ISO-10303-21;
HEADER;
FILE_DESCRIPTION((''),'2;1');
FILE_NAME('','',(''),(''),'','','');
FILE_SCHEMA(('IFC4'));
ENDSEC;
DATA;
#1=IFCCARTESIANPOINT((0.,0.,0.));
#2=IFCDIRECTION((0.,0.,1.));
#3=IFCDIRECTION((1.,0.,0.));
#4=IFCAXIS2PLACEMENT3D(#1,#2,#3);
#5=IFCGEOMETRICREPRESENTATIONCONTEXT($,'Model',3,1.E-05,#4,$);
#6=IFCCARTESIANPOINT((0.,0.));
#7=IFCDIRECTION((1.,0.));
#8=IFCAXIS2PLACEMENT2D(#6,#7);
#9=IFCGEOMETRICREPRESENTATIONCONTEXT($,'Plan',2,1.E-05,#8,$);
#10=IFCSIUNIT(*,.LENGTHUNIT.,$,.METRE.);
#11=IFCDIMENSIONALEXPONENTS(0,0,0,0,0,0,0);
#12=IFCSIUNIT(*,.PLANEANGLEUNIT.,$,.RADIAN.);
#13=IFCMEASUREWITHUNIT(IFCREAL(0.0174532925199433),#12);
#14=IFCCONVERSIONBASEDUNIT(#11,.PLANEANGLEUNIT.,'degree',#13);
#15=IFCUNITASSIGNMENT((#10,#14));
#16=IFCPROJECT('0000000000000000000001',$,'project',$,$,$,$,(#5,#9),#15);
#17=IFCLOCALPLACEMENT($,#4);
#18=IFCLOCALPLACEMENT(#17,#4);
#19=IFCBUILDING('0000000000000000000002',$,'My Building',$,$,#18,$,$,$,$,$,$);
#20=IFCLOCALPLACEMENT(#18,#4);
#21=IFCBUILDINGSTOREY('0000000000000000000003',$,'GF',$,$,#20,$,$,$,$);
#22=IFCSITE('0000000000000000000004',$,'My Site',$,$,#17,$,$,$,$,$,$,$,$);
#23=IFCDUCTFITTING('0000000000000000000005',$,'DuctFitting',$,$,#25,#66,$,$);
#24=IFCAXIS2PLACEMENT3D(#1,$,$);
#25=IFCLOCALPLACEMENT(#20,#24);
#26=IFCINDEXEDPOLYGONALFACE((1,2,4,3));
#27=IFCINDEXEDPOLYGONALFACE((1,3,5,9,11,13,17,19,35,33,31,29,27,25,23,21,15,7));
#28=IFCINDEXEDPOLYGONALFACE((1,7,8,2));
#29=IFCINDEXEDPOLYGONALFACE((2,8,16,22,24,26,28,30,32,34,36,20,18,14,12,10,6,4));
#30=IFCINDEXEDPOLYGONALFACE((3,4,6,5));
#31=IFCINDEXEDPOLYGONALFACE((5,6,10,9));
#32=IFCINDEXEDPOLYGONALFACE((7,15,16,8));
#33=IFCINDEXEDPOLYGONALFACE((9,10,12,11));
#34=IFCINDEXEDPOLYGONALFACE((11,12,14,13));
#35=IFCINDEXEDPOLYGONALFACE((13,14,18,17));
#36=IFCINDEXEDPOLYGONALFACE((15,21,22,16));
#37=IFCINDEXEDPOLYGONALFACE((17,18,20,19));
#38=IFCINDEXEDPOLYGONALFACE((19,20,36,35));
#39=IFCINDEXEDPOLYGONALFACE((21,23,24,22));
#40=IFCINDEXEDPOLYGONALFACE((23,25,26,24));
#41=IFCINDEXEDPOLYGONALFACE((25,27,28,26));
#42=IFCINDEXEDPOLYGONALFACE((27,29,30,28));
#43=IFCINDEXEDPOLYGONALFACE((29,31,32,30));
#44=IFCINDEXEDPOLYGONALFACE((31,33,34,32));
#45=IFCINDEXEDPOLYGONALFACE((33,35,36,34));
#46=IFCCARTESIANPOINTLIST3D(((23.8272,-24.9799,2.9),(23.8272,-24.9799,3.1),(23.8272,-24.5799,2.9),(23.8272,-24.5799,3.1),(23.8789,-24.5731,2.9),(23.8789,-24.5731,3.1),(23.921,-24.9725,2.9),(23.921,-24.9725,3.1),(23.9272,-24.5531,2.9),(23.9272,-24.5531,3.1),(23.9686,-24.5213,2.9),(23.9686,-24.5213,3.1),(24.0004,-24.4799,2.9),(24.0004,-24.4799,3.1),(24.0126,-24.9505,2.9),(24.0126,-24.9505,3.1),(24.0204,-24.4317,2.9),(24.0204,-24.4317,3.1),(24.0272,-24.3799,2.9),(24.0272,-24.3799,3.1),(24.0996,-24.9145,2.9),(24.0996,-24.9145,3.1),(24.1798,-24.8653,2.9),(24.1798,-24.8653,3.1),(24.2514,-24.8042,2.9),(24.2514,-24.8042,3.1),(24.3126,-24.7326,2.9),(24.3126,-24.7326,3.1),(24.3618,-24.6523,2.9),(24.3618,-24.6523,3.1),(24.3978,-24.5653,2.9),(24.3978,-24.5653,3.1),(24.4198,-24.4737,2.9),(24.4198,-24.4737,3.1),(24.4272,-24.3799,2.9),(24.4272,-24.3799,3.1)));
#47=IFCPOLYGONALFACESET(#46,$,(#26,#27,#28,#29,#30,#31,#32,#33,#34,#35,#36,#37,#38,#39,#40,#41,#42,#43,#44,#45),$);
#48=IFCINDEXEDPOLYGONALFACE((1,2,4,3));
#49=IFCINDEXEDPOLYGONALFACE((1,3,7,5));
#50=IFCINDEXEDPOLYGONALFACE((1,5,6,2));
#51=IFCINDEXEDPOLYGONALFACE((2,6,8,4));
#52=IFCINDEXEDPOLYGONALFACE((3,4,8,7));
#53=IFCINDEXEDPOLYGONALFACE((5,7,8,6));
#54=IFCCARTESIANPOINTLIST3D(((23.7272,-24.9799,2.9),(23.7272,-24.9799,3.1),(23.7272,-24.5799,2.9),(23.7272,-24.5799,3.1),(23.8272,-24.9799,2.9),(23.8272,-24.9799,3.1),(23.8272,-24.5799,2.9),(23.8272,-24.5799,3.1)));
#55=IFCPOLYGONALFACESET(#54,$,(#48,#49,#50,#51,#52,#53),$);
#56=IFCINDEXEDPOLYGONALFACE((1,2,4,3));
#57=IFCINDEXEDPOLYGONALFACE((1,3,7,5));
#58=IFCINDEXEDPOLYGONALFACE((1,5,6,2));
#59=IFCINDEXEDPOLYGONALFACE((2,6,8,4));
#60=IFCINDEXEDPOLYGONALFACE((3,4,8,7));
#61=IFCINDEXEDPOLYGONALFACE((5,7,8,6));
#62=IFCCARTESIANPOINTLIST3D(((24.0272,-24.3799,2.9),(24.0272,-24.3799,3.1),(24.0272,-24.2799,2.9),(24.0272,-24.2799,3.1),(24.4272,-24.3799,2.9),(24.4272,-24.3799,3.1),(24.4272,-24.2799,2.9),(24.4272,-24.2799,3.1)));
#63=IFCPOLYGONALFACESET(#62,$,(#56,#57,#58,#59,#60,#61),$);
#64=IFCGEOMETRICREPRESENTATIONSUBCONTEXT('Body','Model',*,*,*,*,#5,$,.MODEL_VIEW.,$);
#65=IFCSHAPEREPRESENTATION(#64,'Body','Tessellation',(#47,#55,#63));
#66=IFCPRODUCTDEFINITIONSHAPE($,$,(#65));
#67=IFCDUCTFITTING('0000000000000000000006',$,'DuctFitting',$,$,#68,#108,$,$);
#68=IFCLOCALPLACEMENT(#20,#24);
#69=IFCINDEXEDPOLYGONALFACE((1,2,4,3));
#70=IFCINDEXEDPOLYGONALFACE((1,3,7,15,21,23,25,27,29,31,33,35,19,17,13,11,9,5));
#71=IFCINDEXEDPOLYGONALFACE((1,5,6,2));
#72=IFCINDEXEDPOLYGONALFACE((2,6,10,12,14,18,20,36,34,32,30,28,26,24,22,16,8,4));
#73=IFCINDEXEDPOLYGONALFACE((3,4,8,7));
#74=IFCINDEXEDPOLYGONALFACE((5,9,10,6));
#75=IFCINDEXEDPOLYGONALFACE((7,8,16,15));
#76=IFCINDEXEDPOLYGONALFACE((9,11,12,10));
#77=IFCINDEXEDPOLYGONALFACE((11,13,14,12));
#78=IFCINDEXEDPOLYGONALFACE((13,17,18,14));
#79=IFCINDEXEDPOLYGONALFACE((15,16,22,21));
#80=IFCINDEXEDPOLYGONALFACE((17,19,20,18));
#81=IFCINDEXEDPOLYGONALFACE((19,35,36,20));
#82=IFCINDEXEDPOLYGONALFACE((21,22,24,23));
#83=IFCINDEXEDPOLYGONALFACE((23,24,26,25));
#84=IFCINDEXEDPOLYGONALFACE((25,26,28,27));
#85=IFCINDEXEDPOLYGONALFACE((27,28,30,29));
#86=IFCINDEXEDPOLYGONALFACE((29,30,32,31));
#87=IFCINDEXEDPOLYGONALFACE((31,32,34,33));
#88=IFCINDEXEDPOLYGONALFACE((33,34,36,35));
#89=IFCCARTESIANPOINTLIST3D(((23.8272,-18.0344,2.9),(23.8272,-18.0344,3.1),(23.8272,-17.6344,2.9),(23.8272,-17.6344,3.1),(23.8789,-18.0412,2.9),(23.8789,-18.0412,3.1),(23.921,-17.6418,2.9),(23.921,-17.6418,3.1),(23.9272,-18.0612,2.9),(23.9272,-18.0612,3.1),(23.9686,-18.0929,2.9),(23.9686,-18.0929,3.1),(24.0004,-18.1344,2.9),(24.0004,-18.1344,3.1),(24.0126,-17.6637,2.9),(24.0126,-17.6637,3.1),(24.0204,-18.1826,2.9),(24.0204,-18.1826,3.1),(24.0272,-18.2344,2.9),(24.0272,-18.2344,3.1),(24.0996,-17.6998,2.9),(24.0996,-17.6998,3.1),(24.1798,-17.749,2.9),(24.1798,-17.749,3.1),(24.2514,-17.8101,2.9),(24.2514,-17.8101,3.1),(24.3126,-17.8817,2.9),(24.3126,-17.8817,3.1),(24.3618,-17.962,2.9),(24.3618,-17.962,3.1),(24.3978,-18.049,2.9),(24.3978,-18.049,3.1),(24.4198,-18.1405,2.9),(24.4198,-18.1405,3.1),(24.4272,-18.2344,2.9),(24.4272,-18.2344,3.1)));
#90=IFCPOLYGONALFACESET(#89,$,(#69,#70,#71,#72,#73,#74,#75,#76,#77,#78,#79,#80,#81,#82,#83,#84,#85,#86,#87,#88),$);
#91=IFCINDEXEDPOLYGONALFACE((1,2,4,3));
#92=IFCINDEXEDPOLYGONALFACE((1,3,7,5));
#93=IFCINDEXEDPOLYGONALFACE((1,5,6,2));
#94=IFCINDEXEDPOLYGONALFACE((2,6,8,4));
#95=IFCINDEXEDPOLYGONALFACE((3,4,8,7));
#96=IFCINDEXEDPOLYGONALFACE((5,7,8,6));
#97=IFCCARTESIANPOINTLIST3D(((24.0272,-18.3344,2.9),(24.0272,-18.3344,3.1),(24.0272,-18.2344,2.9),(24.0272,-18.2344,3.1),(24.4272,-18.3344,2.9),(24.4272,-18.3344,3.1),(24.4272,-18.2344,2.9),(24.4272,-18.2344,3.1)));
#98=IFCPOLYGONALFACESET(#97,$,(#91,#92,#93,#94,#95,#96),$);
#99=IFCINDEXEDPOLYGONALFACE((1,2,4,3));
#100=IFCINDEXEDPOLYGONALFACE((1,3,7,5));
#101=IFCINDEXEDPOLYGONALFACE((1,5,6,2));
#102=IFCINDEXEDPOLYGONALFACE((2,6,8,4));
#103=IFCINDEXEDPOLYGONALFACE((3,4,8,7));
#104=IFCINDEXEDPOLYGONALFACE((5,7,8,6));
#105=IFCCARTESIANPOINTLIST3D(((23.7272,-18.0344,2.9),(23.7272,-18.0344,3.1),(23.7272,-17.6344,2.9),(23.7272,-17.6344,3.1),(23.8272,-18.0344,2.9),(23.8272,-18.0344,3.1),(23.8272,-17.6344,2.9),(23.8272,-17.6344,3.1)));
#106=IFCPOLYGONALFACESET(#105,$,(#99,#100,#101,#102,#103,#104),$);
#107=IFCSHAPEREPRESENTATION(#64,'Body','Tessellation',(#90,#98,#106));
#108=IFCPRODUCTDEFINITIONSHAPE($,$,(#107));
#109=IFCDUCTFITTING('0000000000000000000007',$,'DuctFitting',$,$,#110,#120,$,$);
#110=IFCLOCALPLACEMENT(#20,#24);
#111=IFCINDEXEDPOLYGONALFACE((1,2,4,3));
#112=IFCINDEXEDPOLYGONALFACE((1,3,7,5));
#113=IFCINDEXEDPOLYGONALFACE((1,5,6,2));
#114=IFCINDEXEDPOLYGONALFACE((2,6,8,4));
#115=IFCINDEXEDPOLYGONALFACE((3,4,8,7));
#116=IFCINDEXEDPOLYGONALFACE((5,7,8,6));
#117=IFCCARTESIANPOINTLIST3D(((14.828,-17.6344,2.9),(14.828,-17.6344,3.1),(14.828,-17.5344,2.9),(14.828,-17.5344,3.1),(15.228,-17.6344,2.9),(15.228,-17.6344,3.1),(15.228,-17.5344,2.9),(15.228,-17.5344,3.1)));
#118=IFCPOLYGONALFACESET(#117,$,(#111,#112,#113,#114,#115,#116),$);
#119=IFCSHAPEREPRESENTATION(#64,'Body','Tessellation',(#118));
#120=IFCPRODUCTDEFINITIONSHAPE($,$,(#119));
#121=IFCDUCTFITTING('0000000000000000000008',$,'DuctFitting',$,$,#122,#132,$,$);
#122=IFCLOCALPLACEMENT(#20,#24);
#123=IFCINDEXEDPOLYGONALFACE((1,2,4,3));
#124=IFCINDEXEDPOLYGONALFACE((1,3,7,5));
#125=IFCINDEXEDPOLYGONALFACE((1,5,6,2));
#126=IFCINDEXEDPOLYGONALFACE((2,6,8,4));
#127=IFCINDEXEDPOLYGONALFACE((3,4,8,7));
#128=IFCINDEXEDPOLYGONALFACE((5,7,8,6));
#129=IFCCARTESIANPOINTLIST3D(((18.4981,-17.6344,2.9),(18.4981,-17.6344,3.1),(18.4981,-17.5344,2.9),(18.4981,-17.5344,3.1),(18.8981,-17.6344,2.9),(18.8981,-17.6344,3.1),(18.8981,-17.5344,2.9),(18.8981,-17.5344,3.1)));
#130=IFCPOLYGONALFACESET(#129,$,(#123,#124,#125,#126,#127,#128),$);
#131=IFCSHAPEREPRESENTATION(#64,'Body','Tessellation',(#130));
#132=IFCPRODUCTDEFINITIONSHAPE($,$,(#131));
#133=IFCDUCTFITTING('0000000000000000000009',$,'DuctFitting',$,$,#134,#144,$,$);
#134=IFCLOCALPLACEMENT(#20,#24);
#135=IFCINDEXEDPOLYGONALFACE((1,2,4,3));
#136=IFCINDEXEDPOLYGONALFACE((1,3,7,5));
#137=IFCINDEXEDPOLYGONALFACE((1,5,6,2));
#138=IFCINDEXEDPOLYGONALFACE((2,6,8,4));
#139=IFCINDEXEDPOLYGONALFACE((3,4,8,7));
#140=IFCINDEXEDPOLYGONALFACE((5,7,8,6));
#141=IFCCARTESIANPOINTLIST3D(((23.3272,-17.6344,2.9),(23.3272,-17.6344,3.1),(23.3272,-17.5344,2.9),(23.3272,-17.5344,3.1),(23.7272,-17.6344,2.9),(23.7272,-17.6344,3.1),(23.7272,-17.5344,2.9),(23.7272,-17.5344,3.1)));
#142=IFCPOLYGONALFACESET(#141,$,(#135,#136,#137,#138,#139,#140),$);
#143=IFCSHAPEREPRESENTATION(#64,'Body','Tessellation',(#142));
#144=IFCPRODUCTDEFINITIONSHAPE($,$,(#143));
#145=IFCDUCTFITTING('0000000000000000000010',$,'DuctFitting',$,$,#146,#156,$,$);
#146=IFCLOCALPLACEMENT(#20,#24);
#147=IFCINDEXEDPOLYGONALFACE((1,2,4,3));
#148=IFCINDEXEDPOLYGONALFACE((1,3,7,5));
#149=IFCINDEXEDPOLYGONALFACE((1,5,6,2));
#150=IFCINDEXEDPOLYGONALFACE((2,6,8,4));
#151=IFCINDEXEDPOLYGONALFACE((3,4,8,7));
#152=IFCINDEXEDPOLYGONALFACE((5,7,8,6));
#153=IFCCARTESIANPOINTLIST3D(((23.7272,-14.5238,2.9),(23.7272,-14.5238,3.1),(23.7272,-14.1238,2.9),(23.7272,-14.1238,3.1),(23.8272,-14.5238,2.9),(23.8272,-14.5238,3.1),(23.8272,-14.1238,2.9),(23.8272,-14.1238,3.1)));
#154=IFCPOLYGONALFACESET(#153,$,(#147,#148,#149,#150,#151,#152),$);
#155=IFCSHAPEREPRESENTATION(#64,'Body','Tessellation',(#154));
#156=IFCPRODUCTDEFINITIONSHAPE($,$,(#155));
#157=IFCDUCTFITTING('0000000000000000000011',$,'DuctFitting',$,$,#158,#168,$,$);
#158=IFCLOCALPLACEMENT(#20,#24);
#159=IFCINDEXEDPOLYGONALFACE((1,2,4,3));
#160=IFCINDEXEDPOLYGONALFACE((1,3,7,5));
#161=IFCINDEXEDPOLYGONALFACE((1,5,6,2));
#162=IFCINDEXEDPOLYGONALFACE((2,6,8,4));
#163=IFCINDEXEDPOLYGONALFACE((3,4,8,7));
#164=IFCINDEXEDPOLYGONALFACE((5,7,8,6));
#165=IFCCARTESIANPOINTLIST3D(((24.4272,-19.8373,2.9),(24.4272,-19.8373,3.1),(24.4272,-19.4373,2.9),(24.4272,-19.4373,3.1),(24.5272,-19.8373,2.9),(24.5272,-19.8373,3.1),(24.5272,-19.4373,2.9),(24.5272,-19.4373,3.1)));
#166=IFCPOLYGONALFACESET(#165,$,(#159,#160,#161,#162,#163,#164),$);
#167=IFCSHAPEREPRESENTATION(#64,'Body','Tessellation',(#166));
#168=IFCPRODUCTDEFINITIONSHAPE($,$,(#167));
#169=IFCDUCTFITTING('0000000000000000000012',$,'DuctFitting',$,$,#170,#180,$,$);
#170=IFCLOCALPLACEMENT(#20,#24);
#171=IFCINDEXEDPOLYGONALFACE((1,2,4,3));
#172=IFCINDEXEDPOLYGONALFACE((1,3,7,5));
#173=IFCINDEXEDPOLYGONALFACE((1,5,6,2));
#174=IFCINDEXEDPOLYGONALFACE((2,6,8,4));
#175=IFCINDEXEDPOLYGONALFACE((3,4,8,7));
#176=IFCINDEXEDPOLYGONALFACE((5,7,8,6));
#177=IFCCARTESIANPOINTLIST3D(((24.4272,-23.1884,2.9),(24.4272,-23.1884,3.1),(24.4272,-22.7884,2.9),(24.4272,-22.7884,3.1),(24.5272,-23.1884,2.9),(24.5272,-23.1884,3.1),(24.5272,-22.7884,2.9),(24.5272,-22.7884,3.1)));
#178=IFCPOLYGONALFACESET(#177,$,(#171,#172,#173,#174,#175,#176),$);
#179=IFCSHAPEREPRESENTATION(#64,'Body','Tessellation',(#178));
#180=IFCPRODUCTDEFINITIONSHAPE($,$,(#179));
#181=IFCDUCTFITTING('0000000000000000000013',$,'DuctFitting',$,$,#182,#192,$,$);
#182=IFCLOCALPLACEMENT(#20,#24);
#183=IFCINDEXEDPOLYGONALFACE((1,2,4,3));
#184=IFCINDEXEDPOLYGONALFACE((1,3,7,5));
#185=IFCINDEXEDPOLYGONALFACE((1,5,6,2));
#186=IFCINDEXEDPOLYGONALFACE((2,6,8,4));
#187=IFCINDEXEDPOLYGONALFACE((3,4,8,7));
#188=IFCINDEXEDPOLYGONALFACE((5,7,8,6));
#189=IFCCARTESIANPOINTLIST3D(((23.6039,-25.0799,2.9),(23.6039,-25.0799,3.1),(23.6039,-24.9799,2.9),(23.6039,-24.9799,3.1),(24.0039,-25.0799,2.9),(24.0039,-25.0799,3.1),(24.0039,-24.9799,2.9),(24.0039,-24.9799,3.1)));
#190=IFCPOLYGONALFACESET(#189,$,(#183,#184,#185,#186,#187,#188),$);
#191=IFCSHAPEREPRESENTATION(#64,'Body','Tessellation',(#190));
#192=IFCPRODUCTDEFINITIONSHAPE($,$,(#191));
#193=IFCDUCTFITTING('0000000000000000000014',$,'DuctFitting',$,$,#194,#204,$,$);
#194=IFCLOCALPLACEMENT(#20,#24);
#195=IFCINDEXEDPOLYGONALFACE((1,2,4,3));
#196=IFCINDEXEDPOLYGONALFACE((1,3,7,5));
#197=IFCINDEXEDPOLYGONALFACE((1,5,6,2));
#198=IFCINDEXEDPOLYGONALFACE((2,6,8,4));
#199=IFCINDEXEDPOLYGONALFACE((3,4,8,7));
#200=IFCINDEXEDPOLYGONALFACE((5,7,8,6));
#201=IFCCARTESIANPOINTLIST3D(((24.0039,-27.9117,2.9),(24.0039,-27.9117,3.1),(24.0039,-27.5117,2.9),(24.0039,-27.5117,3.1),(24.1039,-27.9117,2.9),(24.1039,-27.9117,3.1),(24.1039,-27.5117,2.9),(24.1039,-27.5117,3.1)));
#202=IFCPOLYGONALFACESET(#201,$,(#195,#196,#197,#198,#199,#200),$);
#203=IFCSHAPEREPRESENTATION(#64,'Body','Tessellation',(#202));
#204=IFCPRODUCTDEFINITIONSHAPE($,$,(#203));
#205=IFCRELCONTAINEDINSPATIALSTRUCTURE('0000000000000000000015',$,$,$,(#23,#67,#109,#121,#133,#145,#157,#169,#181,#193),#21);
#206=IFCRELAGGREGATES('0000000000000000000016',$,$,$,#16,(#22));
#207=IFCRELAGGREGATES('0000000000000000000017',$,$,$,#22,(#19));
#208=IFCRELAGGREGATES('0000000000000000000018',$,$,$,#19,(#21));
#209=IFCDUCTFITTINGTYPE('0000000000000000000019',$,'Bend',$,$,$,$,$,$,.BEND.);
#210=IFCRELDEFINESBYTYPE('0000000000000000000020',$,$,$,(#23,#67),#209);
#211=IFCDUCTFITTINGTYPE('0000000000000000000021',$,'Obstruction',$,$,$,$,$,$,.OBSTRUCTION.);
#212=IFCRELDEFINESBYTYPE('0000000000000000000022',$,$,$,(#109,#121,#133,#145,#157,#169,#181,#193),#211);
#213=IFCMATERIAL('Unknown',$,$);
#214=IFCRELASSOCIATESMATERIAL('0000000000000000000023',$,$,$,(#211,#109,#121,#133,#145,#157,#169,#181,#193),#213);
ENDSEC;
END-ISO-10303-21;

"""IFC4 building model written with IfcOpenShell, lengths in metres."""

from ifc_helpers import new_model, entity, si_unit, converted_unit, frame, origin_with_axes, origin_2d_with_axis, place, context, subcontext, project, spatial, line, arc, indexed_curve, rectangle, outline, extrude, source, transform, mapped, material, material_profile, profile_set, profile_usage, type_object, type_shapes, element, save


model = new_model("IFC4")

# Units and contexts
model_context = context("Model", 3, precision=1e-05, world=origin_with_axes())
plan_context = context("Plan", 2, precision=1e-05, world=origin_2d_with_axis())
body_context_1 = subcontext(model_context, "Body", "Model", "MODEL_VIEW")
ifc_project = project(units=[si_unit("LENGTHUNIT", "METRE"), converted_unit("PLANEANGLEUNIT", "degree", entity("IfcReal", 0.0174532925199433), si_unit("PLANEANGLEUNIT", "RADIAN"), dimensions=[0, 0, 0, 0, 0, 0, 0])], contexts=[model_context, plan_context])

# Site, building, storey
site_placement = place(None, origin_with_axes())
site = spatial("IfcSite", under=ifc_project, at=site_placement, Name="My Site")
building_placement = place(site_placement, origin_with_axes())
building = spatial("IfcBuilding", under=site, at=building_placement, Name="My Building")
storey_placement = place(building_placement, origin_with_axes())
storey = spatial("IfcBuildingStorey", under=building, at=storey_placement, Name="GF")

# Shared definitions
ifc_material = material(Name="Unknown")

# Duct fittings
duct_fitting_type_1 = type_object("IfcDuctFittingType", Name="Bend", PredefinedType="BEND")
shared_shape_1 = source(origin_with_axes(), body_context_1, "Body", "SweptSolid", [
    extrude(outline(indexed_curve([(-0.2, 0.0), (-0.2586, -0.1414), (-0.4, -0.2), (-0.4, -0.6), (0.0243, -0.4243), (0.2, 0.0)], segments=[arc(1, 2, 3), line(3, 4), arc(4, 5, 6), line(6, 1)])), frame((0.0, -0.1, -0.1), z_axis=(0.0, -1.0, 0.0), x_axis=(1.0, 0.0, 0.0)), (0.0, 0.0, -1.0), 0.2),
    extrude(rectangle(XDim=0.4, YDim=0.2), origin_with_axes(), (0.0, 0.0, -1.0), 0.1),
    extrude(rectangle(XDim=0.4, YDim=0.2), frame((-0.4, 0.0, -0.5), z_axis=(-1.0, 0.0, 0.0), x_axis=(0.0, 0.0, -1.0)), (0.0, 0.0, 1.0), 0.1),
])
type_shapes(duct_fitting_type_1, [shared_shape_1])
for number, where, z_axis, x_axis, name in (
    (1, (23.7272, -24.7799, 3.0), (-1.0, 0.000001, -0.000001), (-0.000001, -1.0, 0.0), "DuctFitting"),
    (2, (24.2272, -18.3344, 3.0), (0.0, -1.0, 0.0), (1.0, 0.0, 0.0), "DuctFitting"),
):
    element("IfcDuctFitting", number, at=place(storey_placement, frame(where, z_axis=z_axis, x_axis=x_axis)), inside=storey, type_object=duct_fitting_type_1, Name=name, context=body_context_1, shape_type="MappedRepresentation", body=[
        mapped(shared_shape_1, transform((0.0, 0.0, 0.0), x_axis=(1.0, 0.0, 0.0), y_axis=(0.0, 1.0, 0.0), z_axis=(0.0, 0.0, 1.0), scale=1.0)),
    ])
ifc_material_profile_1 = material_profile(ifc_material, rectangle(XDim=0.4, YDim=0.2))
ifc_profile_set_1 = profile_set([ifc_material_profile_1])
ifc_profile_usage_1 = profile_usage(ifc_profile_set_1, cardinal=5)
duct_fitting_type_2 = type_object("IfcDuctFittingType", Name="Obstruction", PredefinedType="OBSTRUCTION", material=ifc_profile_set_1)
duct_fitting_1_placement = place(storey_placement, frame((15.028, -17.6344, 3.0), z_axis=(0.0, 1.0, 0.0), x_axis=(-1.0, 0.0, 0.0)))
element("IfcDuctFitting", 3, at=duct_fitting_1_placement, inside=storey, type_object=duct_fitting_type_2, material=ifc_profile_usage_1, Name="DuctFitting", context=body_context_1, shape_type="SweptSolid", body=[
    extrude(rectangle(XDim=0.4, YDim=0.2), origin_with_axes(), (0.0, 0.0, 1.0), 0.1),
])
ifc_profile_usage_2 = profile_usage(ifc_profile_set_1, cardinal=5)
duct_fitting_2_placement = place(storey_placement, frame((18.6981, -17.6344, 3.0), z_axis=(0.0, 1.0, 0.0), x_axis=(-1.0, 0.0, 0.0)))
element("IfcDuctFitting", 4, at=duct_fitting_2_placement, inside=storey, type_object=duct_fitting_type_2, material=ifc_profile_usage_2, Name="DuctFitting", context=body_context_1, shape_type="SweptSolid", body=[
    extrude(rectangle(XDim=0.4, YDim=0.2), origin_with_axes(), (0.0, 0.0, 1.0), 0.1),
])
ifc_profile_usage_3 = profile_usage(ifc_profile_set_1, cardinal=5)
duct_fitting_3_placement = place(storey_placement, frame((23.5272, -17.6344, 3.0), z_axis=(0.0, 1.0, 0.0), x_axis=(-1.0, 0.0, 0.0)))
element("IfcDuctFitting", 5, at=duct_fitting_3_placement, inside=storey, type_object=duct_fitting_type_2, material=ifc_profile_usage_3, Name="DuctFitting", context=body_context_1, shape_type="SweptSolid", body=[
    extrude(rectangle(XDim=0.4, YDim=0.2), origin_with_axes(), (0.0, 0.0, 1.0), 0.1),
])
ifc_profile_usage_4 = profile_usage(ifc_profile_set_1, cardinal=5)
duct_fitting_4_placement = place(storey_placement, frame((23.7272, -14.3238, 3.0), z_axis=(1.0, 0.0, 0.0), x_axis=(0.0, 1.0, 0.0)))
element("IfcDuctFitting", 6, at=duct_fitting_4_placement, inside=storey, type_object=duct_fitting_type_2, material=ifc_profile_usage_4, Name="DuctFitting", context=body_context_1, shape_type="SweptSolid", body=[
    extrude(rectangle(XDim=0.4, YDim=0.2), origin_with_axes(), (0.0, 0.0, 1.0), 0.1),
])
ifc_profile_usage_5 = profile_usage(ifc_profile_set_1, cardinal=5)
duct_fitting_5_placement = place(storey_placement, frame((24.4272, -19.6373, 3.0), z_axis=(1.0, 0.0, 0.0), x_axis=(0.0, 1.0, 0.0)))
element("IfcDuctFitting", 7, at=duct_fitting_5_placement, inside=storey, type_object=duct_fitting_type_2, material=ifc_profile_usage_5, Name="DuctFitting", context=body_context_1, shape_type="SweptSolid", body=[
    extrude(rectangle(XDim=0.4, YDim=0.2), origin_with_axes(), (0.0, 0.0, 1.0), 0.1),
])
ifc_profile_usage_6 = profile_usage(ifc_profile_set_1, cardinal=5)
duct_fitting_6_placement = place(storey_placement, frame((24.4272, -22.9884, 3.0), z_axis=(1.0, 0.0, 0.0), x_axis=(0.0, 1.0, 0.0)))
element("IfcDuctFitting", 8, at=duct_fitting_6_placement, inside=storey, type_object=duct_fitting_type_2, material=ifc_profile_usage_6, Name="DuctFitting", context=body_context_1, shape_type="SweptSolid", body=[
    extrude(rectangle(XDim=0.4, YDim=0.2), origin_with_axes(), (0.0, 0.0, 1.0), 0.1),
])
ifc_profile_usage_7 = profile_usage(ifc_profile_set_1, cardinal=5)
duct_fitting_7_placement = place(storey_placement, frame((23.8039, -24.9799, 3.0), z_axis=(0.0, -1.0, 0.0), x_axis=(1.0, 0.0, 0.0)))
element("IfcDuctFitting", 9, at=duct_fitting_7_placement, inside=storey, type_object=duct_fitting_type_2, material=ifc_profile_usage_7, Name="DuctFitting", context=body_context_1, shape_type="SweptSolid", body=[
    extrude(rectangle(XDim=0.4, YDim=0.2), origin_with_axes(), (0.0, 0.0, 1.0), 0.1),
])
ifc_profile_usage_8 = profile_usage(ifc_profile_set_1, cardinal=5)
duct_fitting_8_placement = place(storey_placement, frame((24.0039, -27.7117, 3.0), z_axis=(1.0, 0.0, 0.0), x_axis=(0.0, 1.0, 0.0)))
element("IfcDuctFitting", 10, at=duct_fitting_8_placement, inside=storey, type_object=duct_fitting_type_2, material=ifc_profile_usage_8, Name="DuctFitting", context=body_context_1, shape_type="SweptSolid", body=[
    extrude(rectangle(XDim=0.4, YDim=0.2), origin_with_axes(), (0.0, 0.0, 1.0), 0.1),
])

save(model, "model.ifc")
